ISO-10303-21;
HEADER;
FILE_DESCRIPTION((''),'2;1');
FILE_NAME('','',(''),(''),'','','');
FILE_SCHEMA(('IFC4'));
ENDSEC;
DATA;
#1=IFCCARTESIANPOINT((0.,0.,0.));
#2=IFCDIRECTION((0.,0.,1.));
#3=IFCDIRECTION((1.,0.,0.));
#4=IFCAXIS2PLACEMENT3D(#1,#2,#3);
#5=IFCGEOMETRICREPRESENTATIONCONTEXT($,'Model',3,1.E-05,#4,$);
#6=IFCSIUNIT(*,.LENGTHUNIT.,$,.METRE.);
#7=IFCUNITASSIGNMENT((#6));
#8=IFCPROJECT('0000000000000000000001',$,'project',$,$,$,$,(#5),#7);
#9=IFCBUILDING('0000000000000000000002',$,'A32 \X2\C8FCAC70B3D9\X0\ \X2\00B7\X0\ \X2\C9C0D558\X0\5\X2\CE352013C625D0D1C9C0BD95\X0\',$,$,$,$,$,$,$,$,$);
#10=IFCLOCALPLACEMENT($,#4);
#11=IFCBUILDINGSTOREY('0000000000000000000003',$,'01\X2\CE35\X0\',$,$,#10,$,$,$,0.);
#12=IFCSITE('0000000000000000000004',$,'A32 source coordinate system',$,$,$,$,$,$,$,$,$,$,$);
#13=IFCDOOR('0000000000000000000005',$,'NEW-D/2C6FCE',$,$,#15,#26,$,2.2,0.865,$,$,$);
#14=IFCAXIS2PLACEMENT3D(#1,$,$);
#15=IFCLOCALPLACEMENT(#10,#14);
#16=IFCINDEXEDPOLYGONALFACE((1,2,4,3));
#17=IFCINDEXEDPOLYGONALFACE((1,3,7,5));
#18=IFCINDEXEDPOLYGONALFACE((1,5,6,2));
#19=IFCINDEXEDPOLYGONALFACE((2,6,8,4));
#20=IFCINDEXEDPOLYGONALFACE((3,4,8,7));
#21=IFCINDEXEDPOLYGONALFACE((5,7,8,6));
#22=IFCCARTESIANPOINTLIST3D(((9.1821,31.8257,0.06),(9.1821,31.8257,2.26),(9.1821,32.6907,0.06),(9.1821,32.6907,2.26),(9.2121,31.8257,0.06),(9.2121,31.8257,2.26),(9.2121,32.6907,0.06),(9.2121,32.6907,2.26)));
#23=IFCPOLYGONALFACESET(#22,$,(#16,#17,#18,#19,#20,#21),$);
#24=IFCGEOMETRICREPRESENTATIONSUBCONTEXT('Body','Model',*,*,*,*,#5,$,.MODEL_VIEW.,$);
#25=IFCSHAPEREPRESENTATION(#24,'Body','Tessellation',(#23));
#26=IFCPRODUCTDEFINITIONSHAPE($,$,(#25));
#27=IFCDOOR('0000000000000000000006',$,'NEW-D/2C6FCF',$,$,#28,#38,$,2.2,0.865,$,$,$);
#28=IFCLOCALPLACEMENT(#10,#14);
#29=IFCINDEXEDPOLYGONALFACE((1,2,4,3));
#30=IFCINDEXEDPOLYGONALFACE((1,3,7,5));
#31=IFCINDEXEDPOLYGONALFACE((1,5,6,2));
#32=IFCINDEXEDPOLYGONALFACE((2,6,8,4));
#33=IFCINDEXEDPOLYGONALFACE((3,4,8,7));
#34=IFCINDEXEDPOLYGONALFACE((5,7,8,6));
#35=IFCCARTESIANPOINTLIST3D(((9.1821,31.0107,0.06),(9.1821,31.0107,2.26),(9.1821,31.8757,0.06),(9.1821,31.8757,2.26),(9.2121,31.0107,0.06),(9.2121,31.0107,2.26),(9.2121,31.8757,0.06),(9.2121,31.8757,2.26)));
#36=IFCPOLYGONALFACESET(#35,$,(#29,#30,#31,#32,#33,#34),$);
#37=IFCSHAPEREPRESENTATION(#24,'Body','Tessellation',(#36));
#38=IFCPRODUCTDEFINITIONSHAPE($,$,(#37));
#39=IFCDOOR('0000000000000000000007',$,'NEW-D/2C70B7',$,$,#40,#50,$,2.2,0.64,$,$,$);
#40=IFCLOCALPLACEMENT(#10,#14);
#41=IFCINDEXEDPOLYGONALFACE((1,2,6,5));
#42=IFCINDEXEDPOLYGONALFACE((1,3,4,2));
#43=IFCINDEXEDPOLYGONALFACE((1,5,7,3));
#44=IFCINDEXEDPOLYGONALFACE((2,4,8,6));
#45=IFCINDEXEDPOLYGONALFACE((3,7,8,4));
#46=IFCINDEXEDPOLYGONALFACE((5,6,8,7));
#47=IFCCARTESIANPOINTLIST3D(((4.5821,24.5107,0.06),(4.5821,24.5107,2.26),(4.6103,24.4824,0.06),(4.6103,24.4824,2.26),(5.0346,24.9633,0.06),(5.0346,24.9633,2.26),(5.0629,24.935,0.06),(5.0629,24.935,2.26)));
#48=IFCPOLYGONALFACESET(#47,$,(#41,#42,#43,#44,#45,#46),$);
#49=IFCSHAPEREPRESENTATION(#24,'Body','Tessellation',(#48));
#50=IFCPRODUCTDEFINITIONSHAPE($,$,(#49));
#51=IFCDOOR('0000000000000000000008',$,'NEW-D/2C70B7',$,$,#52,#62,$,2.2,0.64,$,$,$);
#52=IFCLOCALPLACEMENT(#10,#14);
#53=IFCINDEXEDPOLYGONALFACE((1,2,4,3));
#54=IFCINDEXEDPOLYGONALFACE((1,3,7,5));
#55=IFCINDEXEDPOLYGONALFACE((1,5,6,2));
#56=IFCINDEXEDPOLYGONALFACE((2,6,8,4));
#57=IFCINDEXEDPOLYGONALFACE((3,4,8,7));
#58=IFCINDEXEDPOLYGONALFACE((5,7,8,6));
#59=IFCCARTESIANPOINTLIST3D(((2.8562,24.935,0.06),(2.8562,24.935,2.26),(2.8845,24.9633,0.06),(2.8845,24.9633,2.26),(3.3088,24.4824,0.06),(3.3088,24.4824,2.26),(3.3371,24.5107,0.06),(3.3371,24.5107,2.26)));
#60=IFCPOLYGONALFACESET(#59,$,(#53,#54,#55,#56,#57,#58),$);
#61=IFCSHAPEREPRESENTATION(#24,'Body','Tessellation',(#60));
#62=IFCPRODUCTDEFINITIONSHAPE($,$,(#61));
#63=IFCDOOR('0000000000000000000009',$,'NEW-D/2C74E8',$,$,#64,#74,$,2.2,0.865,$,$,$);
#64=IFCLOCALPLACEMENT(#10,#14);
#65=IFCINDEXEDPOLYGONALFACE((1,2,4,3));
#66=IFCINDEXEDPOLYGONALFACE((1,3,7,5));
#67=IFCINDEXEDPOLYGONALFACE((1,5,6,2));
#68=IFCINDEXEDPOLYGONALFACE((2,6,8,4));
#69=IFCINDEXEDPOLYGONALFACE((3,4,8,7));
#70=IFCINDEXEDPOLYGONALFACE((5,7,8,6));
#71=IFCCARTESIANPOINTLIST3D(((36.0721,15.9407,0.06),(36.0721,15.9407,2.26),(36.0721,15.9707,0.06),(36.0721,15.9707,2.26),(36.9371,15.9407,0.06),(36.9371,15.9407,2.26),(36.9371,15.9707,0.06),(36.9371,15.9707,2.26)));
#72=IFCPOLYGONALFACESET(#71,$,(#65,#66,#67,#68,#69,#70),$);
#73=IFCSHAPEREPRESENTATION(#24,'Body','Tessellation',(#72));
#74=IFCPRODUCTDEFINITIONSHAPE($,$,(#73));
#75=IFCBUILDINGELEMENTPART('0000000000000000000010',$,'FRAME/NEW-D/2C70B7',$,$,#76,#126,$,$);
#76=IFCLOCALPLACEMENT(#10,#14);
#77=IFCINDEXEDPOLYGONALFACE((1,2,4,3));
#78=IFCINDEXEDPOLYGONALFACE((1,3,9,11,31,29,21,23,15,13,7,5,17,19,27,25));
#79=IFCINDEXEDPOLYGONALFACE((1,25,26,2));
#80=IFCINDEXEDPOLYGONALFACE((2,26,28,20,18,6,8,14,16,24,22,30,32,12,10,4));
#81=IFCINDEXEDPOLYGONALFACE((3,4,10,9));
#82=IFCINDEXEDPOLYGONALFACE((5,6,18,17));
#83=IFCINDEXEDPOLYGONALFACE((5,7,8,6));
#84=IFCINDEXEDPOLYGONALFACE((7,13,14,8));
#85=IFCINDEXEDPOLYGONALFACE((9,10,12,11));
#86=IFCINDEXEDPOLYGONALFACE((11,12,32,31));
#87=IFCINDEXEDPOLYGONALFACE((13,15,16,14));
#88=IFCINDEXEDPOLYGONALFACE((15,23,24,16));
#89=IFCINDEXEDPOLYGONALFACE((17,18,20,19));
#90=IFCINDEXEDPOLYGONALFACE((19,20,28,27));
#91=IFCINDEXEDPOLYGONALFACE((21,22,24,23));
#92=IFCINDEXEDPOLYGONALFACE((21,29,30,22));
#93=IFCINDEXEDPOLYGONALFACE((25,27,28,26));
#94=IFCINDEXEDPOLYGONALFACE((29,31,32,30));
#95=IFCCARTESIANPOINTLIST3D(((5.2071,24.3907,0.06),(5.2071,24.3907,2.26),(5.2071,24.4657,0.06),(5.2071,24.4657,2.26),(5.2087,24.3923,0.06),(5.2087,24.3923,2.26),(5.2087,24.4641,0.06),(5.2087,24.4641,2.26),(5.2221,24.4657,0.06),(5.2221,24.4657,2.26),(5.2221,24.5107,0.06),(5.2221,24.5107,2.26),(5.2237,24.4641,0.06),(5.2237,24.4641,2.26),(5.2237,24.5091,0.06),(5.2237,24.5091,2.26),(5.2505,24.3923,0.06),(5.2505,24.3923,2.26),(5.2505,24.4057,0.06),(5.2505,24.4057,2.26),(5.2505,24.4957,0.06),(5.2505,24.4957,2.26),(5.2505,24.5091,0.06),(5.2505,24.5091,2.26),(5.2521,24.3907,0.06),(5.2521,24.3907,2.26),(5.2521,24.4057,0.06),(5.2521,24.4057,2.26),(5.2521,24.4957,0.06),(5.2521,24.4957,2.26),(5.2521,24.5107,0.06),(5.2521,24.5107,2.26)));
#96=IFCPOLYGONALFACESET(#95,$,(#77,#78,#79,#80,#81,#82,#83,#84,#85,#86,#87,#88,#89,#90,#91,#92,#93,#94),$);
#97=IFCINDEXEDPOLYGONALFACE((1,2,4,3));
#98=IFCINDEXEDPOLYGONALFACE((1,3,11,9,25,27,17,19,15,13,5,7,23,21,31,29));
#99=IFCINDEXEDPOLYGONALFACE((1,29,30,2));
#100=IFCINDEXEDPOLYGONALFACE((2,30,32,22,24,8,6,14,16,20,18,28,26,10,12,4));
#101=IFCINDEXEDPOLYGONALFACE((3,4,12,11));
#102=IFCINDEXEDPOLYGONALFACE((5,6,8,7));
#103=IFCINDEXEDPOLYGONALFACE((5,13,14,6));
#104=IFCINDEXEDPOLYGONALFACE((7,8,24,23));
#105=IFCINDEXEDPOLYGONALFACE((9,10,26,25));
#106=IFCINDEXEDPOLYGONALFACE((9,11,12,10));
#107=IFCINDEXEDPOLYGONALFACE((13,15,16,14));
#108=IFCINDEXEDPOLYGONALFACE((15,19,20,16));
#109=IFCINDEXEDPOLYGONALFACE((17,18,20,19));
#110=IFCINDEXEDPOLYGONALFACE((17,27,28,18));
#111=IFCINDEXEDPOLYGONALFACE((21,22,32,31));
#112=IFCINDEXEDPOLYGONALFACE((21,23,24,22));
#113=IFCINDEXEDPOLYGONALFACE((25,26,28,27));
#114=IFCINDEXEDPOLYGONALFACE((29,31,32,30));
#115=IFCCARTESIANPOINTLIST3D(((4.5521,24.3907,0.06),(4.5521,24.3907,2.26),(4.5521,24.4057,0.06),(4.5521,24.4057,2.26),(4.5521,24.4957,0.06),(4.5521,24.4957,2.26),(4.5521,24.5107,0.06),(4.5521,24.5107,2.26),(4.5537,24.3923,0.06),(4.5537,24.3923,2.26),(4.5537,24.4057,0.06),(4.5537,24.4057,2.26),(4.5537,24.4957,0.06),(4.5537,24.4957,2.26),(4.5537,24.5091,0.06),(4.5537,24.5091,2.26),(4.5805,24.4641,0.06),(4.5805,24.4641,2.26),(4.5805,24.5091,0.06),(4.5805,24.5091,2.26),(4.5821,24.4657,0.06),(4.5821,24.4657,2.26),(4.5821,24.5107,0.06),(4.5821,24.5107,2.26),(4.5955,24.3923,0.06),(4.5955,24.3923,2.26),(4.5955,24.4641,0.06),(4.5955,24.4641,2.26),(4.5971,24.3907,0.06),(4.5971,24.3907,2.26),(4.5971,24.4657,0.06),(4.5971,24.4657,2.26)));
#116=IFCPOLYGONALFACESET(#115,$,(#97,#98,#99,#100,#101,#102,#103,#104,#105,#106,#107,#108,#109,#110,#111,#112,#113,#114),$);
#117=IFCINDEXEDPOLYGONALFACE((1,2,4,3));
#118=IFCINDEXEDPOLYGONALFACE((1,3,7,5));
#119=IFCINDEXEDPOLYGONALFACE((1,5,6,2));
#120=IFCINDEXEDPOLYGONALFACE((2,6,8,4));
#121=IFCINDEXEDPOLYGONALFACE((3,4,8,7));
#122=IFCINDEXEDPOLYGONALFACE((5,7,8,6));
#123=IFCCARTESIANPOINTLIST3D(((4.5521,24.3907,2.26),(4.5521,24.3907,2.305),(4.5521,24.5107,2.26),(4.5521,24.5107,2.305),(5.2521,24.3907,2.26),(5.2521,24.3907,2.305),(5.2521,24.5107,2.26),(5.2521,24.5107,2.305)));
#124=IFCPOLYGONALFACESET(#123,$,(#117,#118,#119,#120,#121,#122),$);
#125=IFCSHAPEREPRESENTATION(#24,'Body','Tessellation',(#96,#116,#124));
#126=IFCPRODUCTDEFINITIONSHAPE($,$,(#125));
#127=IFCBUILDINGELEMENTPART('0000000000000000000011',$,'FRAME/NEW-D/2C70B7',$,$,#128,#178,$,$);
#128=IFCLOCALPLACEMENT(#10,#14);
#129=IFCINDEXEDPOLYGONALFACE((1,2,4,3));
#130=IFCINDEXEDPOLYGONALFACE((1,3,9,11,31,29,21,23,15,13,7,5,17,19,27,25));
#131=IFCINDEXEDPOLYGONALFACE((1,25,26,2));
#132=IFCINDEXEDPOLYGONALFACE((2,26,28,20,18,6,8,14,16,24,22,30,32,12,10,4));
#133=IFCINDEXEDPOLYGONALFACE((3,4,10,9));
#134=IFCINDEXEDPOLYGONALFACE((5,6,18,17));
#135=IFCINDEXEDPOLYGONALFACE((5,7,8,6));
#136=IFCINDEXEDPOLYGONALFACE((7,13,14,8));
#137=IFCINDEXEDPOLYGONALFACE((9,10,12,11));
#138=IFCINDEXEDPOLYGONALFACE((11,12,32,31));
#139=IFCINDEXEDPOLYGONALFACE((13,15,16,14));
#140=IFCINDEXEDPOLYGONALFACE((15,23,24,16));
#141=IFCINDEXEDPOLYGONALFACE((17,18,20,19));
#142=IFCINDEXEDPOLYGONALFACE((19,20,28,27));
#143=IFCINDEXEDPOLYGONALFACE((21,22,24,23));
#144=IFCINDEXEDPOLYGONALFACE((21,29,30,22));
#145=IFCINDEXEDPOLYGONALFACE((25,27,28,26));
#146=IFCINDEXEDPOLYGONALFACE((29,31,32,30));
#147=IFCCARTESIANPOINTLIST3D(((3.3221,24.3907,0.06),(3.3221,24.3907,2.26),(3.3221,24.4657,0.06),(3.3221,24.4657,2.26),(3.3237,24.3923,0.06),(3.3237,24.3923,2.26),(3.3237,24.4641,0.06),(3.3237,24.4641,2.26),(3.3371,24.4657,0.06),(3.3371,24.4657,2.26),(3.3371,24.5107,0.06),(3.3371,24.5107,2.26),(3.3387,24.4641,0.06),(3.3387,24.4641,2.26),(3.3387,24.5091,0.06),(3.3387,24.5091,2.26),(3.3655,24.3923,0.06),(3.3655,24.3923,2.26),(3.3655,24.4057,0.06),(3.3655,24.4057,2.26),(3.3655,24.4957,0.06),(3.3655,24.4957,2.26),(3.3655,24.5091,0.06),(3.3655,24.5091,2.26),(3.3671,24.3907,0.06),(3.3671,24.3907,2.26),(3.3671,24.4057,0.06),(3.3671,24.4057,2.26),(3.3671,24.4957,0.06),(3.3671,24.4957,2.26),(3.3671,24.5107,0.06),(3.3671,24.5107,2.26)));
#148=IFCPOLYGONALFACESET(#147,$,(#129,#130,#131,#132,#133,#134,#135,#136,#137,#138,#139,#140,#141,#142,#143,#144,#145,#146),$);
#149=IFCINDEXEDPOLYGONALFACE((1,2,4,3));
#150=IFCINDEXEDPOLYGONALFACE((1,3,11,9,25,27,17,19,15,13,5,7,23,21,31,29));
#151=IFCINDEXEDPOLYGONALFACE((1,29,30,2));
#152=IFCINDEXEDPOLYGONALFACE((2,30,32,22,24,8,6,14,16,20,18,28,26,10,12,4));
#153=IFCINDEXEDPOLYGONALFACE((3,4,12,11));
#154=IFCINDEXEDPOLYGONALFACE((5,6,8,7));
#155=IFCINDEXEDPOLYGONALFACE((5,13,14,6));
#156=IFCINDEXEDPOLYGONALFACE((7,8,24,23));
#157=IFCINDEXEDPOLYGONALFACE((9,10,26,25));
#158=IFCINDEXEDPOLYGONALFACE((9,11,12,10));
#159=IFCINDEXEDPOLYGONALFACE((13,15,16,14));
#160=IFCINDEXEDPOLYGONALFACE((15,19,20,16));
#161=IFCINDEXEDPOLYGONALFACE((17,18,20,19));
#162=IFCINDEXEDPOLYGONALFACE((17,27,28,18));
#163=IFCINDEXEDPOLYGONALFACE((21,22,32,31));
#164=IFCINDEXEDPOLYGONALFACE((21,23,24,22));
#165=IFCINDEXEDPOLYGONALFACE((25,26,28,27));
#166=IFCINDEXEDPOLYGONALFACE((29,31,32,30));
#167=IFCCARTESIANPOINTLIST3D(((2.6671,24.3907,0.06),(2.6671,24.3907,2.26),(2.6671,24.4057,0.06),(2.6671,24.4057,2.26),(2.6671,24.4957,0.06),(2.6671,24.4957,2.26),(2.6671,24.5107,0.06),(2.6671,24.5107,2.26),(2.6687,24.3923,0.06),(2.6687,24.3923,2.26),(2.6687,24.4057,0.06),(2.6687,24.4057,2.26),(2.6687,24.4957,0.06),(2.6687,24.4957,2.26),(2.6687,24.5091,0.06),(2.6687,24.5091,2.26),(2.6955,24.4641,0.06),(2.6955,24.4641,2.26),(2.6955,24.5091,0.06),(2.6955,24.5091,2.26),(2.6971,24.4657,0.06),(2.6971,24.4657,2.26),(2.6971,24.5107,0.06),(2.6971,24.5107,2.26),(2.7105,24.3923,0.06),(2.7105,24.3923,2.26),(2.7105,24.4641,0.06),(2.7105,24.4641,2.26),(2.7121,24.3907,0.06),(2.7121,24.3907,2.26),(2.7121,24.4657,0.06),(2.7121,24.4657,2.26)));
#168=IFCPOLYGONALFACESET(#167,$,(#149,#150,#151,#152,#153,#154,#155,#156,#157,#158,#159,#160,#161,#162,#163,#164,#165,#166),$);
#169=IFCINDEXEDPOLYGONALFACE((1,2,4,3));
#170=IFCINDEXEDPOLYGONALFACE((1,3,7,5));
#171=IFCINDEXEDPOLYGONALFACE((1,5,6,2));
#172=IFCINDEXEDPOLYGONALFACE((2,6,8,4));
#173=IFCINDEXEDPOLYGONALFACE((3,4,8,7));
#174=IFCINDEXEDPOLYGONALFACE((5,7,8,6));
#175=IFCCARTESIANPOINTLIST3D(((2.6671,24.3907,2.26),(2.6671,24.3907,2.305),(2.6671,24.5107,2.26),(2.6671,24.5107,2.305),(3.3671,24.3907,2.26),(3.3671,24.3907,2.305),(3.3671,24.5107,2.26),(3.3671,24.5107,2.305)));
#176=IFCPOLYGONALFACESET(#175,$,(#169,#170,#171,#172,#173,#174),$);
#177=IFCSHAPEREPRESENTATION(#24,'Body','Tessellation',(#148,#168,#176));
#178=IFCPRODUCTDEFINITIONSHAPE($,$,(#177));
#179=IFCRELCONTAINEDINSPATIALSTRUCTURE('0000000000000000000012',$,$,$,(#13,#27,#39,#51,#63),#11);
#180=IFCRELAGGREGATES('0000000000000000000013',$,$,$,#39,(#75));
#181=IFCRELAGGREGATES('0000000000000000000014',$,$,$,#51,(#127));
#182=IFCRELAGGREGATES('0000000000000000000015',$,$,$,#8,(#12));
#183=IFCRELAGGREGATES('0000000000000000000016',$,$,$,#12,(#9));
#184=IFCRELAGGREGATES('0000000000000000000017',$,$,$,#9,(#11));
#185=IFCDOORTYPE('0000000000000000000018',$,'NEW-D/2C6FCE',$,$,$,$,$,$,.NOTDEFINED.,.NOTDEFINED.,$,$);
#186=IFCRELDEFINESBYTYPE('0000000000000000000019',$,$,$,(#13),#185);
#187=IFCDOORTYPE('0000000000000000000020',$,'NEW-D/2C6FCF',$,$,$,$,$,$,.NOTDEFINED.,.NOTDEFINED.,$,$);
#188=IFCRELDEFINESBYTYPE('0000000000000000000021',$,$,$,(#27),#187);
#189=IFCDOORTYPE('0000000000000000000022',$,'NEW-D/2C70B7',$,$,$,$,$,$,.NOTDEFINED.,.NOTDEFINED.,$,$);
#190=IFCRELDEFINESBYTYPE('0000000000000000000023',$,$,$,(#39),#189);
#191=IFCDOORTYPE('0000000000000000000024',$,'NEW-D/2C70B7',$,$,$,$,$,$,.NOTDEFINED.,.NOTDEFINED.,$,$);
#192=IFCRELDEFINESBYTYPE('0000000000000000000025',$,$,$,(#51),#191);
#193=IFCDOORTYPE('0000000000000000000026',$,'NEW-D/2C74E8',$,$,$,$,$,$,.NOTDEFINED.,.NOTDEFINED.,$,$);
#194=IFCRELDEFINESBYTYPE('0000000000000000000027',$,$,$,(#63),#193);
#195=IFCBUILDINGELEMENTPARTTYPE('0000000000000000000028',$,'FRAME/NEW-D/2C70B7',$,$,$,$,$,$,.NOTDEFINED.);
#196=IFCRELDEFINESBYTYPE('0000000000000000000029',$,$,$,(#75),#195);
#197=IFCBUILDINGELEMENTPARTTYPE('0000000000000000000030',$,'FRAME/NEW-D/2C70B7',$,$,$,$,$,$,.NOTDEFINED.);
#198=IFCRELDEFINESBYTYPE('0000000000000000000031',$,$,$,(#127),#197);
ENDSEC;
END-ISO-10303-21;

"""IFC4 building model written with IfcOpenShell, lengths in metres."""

from ifc_helpers import new_model, si_unit, frame, origin, origin_with_axes, place, context, subcontext, project, spatial, polyline, outline, extrude, source, transform, mapped, type_object, type_shapes, element, aggregate, save


model = new_model("IFC4")

# Units and contexts
model_context = context("Model", 3, precision=1e-05, world=origin_with_axes())
body_context = subcontext(model_context, "Body", "Model", "MODEL_VIEW")
ifc_project = project(units=[si_unit("LENGTHUNIT", "METRE")], contexts=[model_context])

# Site, building, storey
site = spatial("IfcSite", under=ifc_project, Name="A32 source coordinate system")
building = spatial("IfcBuilding", under=site, Name="A32 주거동 · 지하5층–옥탑지붕")
storey_placement = place(None, origin_with_axes())
storey = spatial("IfcBuildingStorey", under=building, at=storey_placement, Name="01층", Elevation=0.0)

# Doors
door_type_1 = type_object("IfcDoorType", Name="NEW-D/2C6FCE", OperationType="NOTDEFINED", PredefinedType="NOTDEFINED")
shared_shape_1 = source(origin(), body_context, "Body", "SweptSolid", [
    extrude(outline(polyline([(9.1821, 32.6907), (9.2121, 32.6907), (9.2121, 31.8257), (9.1821, 31.8257), (9.1821, 32.6907)])), frame((0.0, 0.0, 0.06)), (0.0, 0.0, 1.0), 2.2),
])
type_shapes(door_type_1, [shared_shape_1])
door_1_placement = place(storey_placement, origin_with_axes())
element("IfcDoor", 1, at=door_1_placement, inside=storey, type_object=door_type_1, Name="NEW-D/2C6FCE", OverallHeight=2.2, OverallWidth=0.865, context=body_context, shape_type="MappedRepresentation", body=[
    mapped(shared_shape_1, transform((0.0, 0.0, 0.0), scale=1.0)),
])
door_type_2 = type_object("IfcDoorType", Name="NEW-D/2C6FCF", OperationType="NOTDEFINED", PredefinedType="NOTDEFINED")
shared_shape_2 = source(origin(), body_context, "Body", "SweptSolid", [
    extrude(outline(polyline([(9.2121, 31.8757), (9.2121, 31.0107), (9.1821, 31.0107), (9.1821, 31.8757), (9.2121, 31.8757)])), frame((0.0, 0.0, 0.06)), (0.0, 0.0, 1.0), 2.2),
])
type_shapes(door_type_2, [shared_shape_2])
door_2_placement = place(storey_placement, origin_with_axes())
element("IfcDoor", 2, at=door_2_placement, inside=storey, type_object=door_type_2, Name="NEW-D/2C6FCF", OverallHeight=2.2, OverallWidth=0.865, context=body_context, shape_type="MappedRepresentation", body=[
    mapped(shared_shape_2, transform((0.0, 0.0, 0.0), scale=1.0)),
])

# Doors
door_type_3 = type_object("IfcDoorType", Name="NEW-D/2C70B7", OperationType="NOTDEFINED", PredefinedType="NOTDEFINED")
shared_shape_3 = source(origin(), body_context, "Body", "SweptSolid", [
    extrude(outline(polyline([(5.0629, 24.935), (4.6103, 24.4824), (4.5821, 24.5107), (5.0346, 24.9633), (5.0629, 24.935)])), frame((0.0, 0.0, 0.06)), (0.0, 0.0, 1.0), 2.2),
])
type_shapes(door_type_3, [shared_shape_3])
door_3_placement = place(storey_placement, origin_with_axes())
door_3 = element("IfcDoor", 3, at=door_3_placement, inside=storey, type_object=door_type_3, Name="NEW-D/2C70B7", OverallHeight=2.2, OverallWidth=0.64, context=body_context, shape_type="MappedRepresentation", body=[
    mapped(shared_shape_3, transform((0.0, 0.0, 0.0), scale=1.0)),
])
door_type_4 = type_object("IfcDoorType", Name="NEW-D/2C70B7", OperationType="NOTDEFINED", PredefinedType="NOTDEFINED")
shared_shape_4 = source(origin(), body_context, "Body", "SweptSolid", [
    extrude(outline(polyline([(3.3371, 24.5107), (3.3088, 24.4824), (2.8562, 24.935), (2.8845, 24.9633), (3.3371, 24.5107)])), frame((0.0, 0.0, 0.06)), (0.0, 0.0, 1.0), 2.2),
])
type_shapes(door_type_4, [shared_shape_4])
door_4_placement = place(storey_placement, origin_with_axes())
door_4 = element("IfcDoor", 4, at=door_4_placement, inside=storey, type_object=door_type_4, Name="NEW-D/2C70B7", OverallHeight=2.2, OverallWidth=0.64, context=body_context, shape_type="MappedRepresentation", body=[
    mapped(shared_shape_4, transform((0.0, 0.0, 0.0), scale=1.0)),
])

# Door
door_type_5 = type_object("IfcDoorType", Name="NEW-D/2C74E8", OperationType="NOTDEFINED", PredefinedType="NOTDEFINED")
shared_shape_5 = source(origin(), body_context, "Body", "SweptSolid", [
    extrude(outline(polyline([(36.9371, 15.9707), (36.9371, 15.9407), (36.0721, 15.9407), (36.0721, 15.9707), (36.9371, 15.9707)])), frame((0.0, 0.0, 0.06)), (0.0, 0.0, 1.0), 2.2),
])
type_shapes(door_type_5, [shared_shape_5])
door_5_placement = place(storey_placement, origin_with_axes())
element("IfcDoor", 5, at=door_5_placement, inside=storey, type_object=door_type_5, Name="NEW-D/2C74E8", OverallHeight=2.2, OverallWidth=0.865, context=body_context, shape_type="MappedRepresentation", body=[
    mapped(shared_shape_5, transform((0.0, 0.0, 0.0), scale=1.0)),
])

# Building element parts
building_element_part_type_1 = type_object("IfcBuildingElementPartType", Name="FRAME/NEW-D/2C70B7", PredefinedType="NOTDEFINED")
shared_shape_6 = source(origin(), body_context, "Body", "SweptSolid", [
    extrude(outline(polyline([(5.2237, 24.5091), (5.2237, 24.4641), (5.2087, 24.4641), (5.2087, 24.3923), (5.2505, 24.3923), (5.2505, 24.4057), (5.2521, 24.4057), (5.2521, 24.3907), (5.2071, 24.3907), (5.2071, 24.4657), (5.2221, 24.4657), (5.2221, 24.5107), (5.2521, 24.5107), (5.2521, 24.4957), (5.2505, 24.4957), (5.2505, 24.5091), (5.2237, 24.5091)])), frame((0.0, 0.0, 0.06)), (0.0, 0.0, 1.0), 2.2),
    extrude(outline(polyline([(4.5521, 24.5107), (4.5821, 24.5107), (4.5821, 24.4657), (4.5971, 24.4657), (4.5971, 24.3907), (4.5521, 24.3907), (4.5521, 24.4057), (4.5537, 24.4057), (4.5537, 24.3923), (4.5955, 24.3923), (4.5955, 24.4641), (4.5805, 24.4641), (4.5805, 24.5091), (4.5537, 24.5091), (4.5537, 24.4957), (4.5521, 24.4957), (4.5521, 24.5107)])), frame((0.0, 0.0, 0.06)), (0.0, 0.0, 1.0), 2.2),
    extrude(outline(polyline([(5.2521, 24.3907), (5.2521, 24.5107), (4.5521, 24.5107), (4.5521, 24.3907), (5.2521, 24.3907)])), frame((0.0, 0.0, 2.26)), (0.0, 0.0, 1.0), 0.045),
])
type_shapes(building_element_part_type_1, [shared_shape_6])
building_element_part_1_placement = place(door_3_placement, origin_with_axes())
building_element_part_1 = element("IfcBuildingElementPart", 6, at=building_element_part_1_placement, type_object=building_element_part_type_1, Name="FRAME/NEW-D/2C70B7", context=body_context, shape_type="MappedRepresentation", body=[
    mapped(shared_shape_6, transform((0.0, 0.0, 0.0), scale=1.0)),
])
aggregate(door_3, [building_element_part_1])
building_element_part_type_2 = type_object("IfcBuildingElementPartType", Name="FRAME/NEW-D/2C70B7", PredefinedType="NOTDEFINED")
shared_shape_7 = source(origin(), body_context, "Body", "SweptSolid", [
    extrude(outline(polyline([(3.3387, 24.5091), (3.3387, 24.4641), (3.3237, 24.4641), (3.3237, 24.3923), (3.3655, 24.3923), (3.3655, 24.4057), (3.3671, 24.4057), (3.3671, 24.3907), (3.3221, 24.3907), (3.3221, 24.4657), (3.3371, 24.4657), (3.3371, 24.5107), (3.3671, 24.5107), (3.3671, 24.4957), (3.3655, 24.4957), (3.3655, 24.5091), (3.3387, 24.5091)])), frame((0.0, 0.0, 0.06)), (0.0, 0.0, 1.0), 2.2),
    extrude(outline(polyline([(2.6671, 24.5107), (2.6971, 24.5107), (2.6971, 24.4657), (2.7121, 24.4657), (2.7121, 24.3907), (2.6671, 24.3907), (2.6671, 24.4057), (2.6687, 24.4057), (2.6687, 24.3923), (2.7105, 24.3923), (2.7105, 24.4641), (2.6955, 24.4641), (2.6955, 24.5091), (2.6687, 24.5091), (2.6687, 24.4957), (2.6671, 24.4957), (2.6671, 24.5107)])), frame((0.0, 0.0, 0.06)), (0.0, 0.0, 1.0), 2.2),
    extrude(outline(polyline([(3.3671, 24.3907), (3.3671, 24.5107), (2.6671, 24.5107), (2.6671, 24.3907), (3.3671, 24.3907)])), frame((0.0, 0.0, 2.26)), (0.0, 0.0, 1.0), 0.045),
])
type_shapes(building_element_part_type_2, [shared_shape_7])
building_element_part_2_placement = place(door_4_placement, origin_with_axes())
building_element_part_2 = element("IfcBuildingElementPart", 7, at=building_element_part_2_placement, type_object=building_element_part_type_2, Name="FRAME/NEW-D/2C70B7", context=body_context, shape_type="MappedRepresentation", body=[
    mapped(shared_shape_7, transform((0.0, 0.0, 0.0), scale=1.0)),
])
aggregate(door_4, [building_element_part_2])

save(model, "model.ifc")
